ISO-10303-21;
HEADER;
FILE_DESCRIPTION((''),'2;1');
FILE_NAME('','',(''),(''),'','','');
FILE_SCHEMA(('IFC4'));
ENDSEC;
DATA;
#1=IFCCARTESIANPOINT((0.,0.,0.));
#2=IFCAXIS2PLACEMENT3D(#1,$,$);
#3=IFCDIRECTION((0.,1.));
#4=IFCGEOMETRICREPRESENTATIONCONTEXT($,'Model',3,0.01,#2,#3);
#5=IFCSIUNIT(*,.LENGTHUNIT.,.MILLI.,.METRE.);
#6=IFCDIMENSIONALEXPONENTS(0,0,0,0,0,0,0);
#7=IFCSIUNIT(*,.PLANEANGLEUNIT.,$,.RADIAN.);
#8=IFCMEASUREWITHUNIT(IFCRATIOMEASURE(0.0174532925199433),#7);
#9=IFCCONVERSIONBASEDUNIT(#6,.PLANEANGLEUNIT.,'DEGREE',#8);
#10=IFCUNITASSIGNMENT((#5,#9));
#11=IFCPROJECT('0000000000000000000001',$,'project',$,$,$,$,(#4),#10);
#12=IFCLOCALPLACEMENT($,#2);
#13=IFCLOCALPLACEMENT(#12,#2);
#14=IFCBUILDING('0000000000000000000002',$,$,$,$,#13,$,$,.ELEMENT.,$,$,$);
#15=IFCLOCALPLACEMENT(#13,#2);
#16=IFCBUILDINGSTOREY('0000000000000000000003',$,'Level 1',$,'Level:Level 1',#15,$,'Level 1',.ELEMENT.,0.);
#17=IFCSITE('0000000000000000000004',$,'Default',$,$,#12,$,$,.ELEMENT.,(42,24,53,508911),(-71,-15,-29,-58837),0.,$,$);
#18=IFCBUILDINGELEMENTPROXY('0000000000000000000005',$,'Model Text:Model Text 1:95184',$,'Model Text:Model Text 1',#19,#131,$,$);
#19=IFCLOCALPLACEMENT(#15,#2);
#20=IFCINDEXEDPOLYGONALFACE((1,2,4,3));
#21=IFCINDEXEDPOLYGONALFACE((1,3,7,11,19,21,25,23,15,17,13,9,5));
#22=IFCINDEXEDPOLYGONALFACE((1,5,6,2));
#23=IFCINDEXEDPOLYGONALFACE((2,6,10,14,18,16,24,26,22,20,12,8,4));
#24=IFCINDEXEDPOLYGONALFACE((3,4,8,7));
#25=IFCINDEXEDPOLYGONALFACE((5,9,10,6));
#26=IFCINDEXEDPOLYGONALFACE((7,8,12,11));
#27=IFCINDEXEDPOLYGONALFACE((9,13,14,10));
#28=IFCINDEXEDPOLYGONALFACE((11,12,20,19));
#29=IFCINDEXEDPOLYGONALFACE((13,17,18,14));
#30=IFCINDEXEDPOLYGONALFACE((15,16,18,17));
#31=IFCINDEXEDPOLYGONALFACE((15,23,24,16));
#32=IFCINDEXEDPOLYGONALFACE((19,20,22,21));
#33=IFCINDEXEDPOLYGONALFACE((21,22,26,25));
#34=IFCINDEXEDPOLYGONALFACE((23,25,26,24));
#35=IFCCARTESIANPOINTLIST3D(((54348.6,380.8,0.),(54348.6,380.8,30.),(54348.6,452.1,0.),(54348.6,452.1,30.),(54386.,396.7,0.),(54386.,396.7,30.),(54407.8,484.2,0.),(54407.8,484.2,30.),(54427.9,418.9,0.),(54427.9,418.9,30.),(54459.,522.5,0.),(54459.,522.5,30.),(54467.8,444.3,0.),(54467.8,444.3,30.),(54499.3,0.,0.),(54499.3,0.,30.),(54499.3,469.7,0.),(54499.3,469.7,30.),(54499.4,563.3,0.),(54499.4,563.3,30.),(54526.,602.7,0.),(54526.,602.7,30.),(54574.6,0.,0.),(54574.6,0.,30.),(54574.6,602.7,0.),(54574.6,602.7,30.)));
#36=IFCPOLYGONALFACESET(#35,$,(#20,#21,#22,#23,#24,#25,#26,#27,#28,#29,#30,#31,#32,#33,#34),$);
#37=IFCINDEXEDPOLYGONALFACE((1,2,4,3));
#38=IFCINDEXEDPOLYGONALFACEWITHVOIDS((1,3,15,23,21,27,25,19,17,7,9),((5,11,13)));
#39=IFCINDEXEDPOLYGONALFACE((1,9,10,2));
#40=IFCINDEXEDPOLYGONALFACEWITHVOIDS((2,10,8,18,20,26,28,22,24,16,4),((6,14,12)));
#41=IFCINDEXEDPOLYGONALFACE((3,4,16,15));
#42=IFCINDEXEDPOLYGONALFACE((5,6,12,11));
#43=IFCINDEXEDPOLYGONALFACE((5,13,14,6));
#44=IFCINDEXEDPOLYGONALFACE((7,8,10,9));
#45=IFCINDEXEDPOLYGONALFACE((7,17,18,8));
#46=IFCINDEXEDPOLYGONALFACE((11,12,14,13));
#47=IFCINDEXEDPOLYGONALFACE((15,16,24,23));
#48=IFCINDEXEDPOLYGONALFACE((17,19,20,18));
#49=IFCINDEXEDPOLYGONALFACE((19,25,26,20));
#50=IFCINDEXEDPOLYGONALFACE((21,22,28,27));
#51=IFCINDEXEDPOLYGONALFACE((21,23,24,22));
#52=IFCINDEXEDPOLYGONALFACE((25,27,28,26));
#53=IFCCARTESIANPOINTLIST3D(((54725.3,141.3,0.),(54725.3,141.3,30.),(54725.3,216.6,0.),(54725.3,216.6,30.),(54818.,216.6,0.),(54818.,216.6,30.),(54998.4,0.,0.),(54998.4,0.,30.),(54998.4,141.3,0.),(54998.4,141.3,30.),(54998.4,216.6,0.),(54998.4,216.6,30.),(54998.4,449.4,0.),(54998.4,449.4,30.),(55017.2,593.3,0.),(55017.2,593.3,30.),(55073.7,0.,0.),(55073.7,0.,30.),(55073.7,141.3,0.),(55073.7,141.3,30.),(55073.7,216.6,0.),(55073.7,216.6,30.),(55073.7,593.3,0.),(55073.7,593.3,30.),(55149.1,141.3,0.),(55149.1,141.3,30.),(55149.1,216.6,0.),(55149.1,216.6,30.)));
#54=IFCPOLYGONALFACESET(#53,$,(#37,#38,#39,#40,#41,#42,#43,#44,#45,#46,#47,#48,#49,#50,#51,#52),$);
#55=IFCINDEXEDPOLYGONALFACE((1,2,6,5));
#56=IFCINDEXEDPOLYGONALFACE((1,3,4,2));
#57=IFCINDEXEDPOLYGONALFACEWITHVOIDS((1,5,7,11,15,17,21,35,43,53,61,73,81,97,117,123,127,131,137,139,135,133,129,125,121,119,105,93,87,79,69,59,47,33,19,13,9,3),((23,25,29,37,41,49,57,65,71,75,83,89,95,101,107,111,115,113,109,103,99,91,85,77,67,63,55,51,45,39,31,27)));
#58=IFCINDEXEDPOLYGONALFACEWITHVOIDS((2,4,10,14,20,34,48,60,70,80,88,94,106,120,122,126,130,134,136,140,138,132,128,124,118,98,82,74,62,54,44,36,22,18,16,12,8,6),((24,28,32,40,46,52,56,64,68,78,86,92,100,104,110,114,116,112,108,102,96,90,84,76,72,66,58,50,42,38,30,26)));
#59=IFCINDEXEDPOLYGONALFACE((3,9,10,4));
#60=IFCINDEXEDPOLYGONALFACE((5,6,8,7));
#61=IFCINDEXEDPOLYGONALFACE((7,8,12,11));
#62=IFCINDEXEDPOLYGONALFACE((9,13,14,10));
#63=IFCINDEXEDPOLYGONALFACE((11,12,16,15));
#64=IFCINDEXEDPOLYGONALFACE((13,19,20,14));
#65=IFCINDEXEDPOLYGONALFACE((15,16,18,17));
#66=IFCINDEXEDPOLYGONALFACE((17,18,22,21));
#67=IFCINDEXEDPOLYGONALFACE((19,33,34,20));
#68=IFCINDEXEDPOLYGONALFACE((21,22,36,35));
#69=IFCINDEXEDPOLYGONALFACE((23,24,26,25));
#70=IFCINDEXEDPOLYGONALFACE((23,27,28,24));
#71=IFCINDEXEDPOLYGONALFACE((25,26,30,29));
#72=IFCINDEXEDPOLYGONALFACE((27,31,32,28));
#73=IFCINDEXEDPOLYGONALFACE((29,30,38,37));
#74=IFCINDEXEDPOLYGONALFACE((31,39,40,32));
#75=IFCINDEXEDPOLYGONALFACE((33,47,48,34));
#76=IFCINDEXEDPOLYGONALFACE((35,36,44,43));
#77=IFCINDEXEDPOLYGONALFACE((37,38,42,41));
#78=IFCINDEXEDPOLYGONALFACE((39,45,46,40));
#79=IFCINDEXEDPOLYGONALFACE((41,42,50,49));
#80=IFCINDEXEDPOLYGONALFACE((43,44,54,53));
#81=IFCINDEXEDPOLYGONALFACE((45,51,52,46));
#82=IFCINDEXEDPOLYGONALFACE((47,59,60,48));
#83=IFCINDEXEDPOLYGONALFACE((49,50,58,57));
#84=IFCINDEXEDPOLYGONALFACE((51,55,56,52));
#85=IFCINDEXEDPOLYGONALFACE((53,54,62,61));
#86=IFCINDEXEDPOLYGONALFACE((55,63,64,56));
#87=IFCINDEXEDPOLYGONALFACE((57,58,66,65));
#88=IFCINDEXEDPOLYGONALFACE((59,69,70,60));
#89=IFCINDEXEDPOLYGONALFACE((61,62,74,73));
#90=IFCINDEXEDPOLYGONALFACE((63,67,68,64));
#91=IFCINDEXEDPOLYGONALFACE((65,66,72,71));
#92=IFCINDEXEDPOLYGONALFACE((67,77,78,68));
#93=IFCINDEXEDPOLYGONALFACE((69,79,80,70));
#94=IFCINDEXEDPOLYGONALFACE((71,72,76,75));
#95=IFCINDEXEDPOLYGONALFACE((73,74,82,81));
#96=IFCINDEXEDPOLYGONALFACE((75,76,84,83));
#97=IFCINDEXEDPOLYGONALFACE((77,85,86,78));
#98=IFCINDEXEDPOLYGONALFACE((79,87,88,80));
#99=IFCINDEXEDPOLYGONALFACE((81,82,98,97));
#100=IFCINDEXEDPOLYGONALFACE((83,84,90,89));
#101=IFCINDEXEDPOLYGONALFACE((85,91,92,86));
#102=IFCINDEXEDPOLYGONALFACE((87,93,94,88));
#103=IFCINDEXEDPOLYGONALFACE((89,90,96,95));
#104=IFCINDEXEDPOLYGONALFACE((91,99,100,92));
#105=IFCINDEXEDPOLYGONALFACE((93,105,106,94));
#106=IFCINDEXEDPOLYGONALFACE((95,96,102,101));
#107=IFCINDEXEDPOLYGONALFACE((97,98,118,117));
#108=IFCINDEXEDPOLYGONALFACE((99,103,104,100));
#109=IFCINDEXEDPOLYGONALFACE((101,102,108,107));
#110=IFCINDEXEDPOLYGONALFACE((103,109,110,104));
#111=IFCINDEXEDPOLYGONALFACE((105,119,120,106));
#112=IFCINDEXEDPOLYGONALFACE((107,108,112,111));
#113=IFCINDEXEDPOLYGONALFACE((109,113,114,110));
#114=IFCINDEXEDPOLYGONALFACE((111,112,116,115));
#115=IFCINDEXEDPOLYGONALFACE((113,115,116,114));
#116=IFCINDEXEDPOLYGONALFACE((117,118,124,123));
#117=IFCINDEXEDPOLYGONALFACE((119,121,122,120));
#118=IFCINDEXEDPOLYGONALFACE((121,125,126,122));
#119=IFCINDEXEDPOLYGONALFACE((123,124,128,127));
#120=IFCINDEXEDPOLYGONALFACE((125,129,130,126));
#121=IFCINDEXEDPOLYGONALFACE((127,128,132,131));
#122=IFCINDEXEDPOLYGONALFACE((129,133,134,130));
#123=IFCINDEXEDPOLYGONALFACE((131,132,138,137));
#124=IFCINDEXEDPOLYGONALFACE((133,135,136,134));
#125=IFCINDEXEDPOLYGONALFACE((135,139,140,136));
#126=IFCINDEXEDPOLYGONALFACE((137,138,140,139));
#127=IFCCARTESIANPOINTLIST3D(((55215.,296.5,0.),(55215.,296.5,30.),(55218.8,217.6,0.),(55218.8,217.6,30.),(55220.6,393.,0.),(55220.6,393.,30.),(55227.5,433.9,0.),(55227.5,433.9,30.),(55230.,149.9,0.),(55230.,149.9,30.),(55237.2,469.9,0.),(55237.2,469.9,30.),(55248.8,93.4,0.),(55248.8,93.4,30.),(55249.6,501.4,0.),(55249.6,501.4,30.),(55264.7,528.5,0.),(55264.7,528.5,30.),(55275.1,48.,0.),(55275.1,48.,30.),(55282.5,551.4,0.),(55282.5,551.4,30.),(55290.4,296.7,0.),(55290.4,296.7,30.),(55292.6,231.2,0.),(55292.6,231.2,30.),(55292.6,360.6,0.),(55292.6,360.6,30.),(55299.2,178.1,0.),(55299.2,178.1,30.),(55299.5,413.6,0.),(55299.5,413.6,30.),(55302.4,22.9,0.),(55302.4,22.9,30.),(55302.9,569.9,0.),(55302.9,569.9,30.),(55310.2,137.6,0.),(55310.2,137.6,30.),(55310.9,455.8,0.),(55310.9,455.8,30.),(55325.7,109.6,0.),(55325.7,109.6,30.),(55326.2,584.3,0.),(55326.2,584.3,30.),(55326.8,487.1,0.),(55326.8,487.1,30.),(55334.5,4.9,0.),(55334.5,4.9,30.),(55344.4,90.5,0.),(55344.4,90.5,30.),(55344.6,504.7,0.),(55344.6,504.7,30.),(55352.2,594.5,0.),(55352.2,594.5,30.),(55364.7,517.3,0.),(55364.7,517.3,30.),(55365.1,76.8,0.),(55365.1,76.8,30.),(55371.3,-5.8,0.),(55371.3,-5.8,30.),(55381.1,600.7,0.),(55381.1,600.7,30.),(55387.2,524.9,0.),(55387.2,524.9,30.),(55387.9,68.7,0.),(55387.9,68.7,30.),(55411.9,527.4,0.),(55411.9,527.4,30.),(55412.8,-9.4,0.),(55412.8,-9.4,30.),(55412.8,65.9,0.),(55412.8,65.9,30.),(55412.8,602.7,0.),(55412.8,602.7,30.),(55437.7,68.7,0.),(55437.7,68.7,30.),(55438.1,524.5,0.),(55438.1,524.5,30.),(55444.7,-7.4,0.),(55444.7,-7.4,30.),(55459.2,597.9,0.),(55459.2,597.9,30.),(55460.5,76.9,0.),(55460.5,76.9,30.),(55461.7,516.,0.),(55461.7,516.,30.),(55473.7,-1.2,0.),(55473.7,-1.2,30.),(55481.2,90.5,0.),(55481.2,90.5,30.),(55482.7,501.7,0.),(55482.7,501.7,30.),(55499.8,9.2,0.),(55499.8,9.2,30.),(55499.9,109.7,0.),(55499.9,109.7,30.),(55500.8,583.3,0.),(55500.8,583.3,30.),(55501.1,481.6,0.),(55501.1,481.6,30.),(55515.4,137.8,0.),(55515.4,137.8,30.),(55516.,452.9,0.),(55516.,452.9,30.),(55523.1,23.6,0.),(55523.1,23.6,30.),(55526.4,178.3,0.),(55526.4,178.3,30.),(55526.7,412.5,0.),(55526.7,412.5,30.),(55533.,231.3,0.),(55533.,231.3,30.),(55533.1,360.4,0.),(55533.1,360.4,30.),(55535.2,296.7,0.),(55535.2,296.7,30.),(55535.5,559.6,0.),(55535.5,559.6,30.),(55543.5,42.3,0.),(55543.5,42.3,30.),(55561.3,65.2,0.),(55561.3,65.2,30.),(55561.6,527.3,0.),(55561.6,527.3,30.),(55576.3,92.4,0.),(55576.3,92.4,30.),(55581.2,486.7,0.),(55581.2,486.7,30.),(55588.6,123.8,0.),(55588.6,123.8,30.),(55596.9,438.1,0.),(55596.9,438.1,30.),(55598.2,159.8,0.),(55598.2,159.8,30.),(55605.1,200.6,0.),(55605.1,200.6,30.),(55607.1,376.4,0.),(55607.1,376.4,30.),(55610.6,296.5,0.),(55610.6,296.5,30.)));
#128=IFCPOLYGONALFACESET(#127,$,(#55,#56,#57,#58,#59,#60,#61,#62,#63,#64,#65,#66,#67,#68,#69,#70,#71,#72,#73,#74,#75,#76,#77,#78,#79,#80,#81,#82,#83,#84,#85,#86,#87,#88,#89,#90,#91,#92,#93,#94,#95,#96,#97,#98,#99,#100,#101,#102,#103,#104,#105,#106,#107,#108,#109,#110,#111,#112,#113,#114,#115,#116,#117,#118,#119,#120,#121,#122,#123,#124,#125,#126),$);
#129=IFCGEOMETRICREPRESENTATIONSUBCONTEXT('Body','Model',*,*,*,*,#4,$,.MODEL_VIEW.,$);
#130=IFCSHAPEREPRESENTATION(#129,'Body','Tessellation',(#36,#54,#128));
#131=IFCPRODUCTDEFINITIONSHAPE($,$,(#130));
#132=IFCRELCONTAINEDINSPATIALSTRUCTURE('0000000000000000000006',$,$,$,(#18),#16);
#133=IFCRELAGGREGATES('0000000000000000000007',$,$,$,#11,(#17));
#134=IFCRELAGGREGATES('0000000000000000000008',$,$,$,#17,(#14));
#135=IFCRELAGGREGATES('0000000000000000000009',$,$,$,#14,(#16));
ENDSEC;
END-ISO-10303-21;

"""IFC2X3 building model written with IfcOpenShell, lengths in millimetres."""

from ifc_helpers import new_model, entity, si_unit, converted_unit, direction, frame, origin, place, context, subcontext, project, spatial, polyline, outline, extrude, element, save


model = new_model("IFC2X3")

# Units and contexts
model_context = context("Model", 3, precision=0.01, world=origin(), true_north=direction((0.0, 1.0)))
body_context = subcontext(model_context, "Body", "Model", "MODEL_VIEW")
ifc_project = project(units=[si_unit("LENGTHUNIT", "METRE", prefix="MILLI"), converted_unit("PLANEANGLEUNIT", "DEGREE", entity("IfcRatioMeasure", 0.0174532925199433), si_unit("PLANEANGLEUNIT", "RADIAN"), dimensions=[0, 0, 0, 0, 0, 0, 0])], contexts=[model_context])

# Site, building, storey
site_placement = place(None, origin())
site = spatial("IfcSite", under=ifc_project, at=site_placement, Name="Default", CompositionType="ELEMENT", RefLatitude=(42, 24, 53, 508911), RefLongitude=(-71, -15, -29, -58837), RefElevation=0.0)
building_placement = place(site_placement, origin())
building = spatial("IfcBuilding", under=site, at=building_placement, CompositionType="ELEMENT")
storey_placement = place(building_placement, origin())
storey = spatial("IfcBuildingStorey", under=building, at=storey_placement, Name="Level 1", ObjectType="Level:Level 1", LongName="Level 1", CompositionType="ELEMENT", Elevation=0.0)

# Building element proxy
proxy_1_placement = place(storey_placement, origin())
element("IfcBuildingElementProxy", 1, at=proxy_1_placement, inside=storey, Name="Model Text:Model Text 1:95184", ObjectType="Model Text:Model Text 1", context=body_context, shape_type="SweptSolid", body=[
    extrude(outline(polyline([(-410.6, -111.6), (192.1, -111.6), (192.1, -63.1), (152.7, -36.4), (111.9, 4.0), (73.6, 55.2), (41.4, 114.4), (-29.8, 114.4), (-13.9, 77.0), (8.3, 35.1), (33.7, -4.8), (59.1, -36.3), (-410.6, -36.3), (-410.6, -111.6)])), frame((54463.0, 410.6, 0.0), z_axis=(0.0, 0.0, 1.0), x_axis=(0.0, 1.0, 0.0)), (0.0, 0.0, 1.0), 30.0),
    extrude(outline(polyline([(-6.8, -218.3), (68.5, -218.3), (68.5, -77.1), (143.8, -77.1), (143.8, -1.7), (68.5, -1.7), (68.5, 375.0), (12.0, 375.0), (-280.0, -1.7), (-280.0, -77.1), (-6.8, -77.1), (-6.8, -218.3)]), holes=[polyline([(-6.8, -1.7), (-187.3, -1.7), (-6.8, 231.1), (-6.8, -1.7)])]), frame((55005.3, 218.3, 0.0)), (0.0, 0.0, 1.0), 30.0),
    extrude(outline(polyline([(-10.6, -198.7), (68.3, -198.7), (136.5, -190.7), (193.9, -174.7), (240.5, -150.6), (266.9, -124.4), (286.3, -93.2), (298.8, -57.0), (304.3, -15.7), (303.8, 16.2), (299.0, 45.5), (289.9, 72.1), (276.6, 96.0), (258.9, 117.3), (236.9, 136.2), (210.4, 152.5), (179.6, 166.3), (144.1, 177.6), (103.7, 186.3), (8.2, 196.4), (-71.8, 196.7), (-134.0, 189.4), (-183.3, 176.1), (-224.7, 158.4), (-258.2, 133.9), (-283.5, 100.3), (-300.1, 59.5), (-307.1, 13.4), (-306.6, -18.4), (-301.8, -47.5), (-292.8, -74.0), (-279.6, -97.9), (-262.0, -119.2), (-240.0, -138.1), (-213.6, -154.5), (-182.8, -168.4), (-147.3, -179.8), (-106.7, -188.6), (-10.6, -198.7)]), holes=[polyline([(-7.2, -123.5), (-71.0, -118.2), (-123.6, -108.8), (-165.2, -95.4), (-195.7, -78.0), (-212.4, -59.4), (-224.1, -38.7), (-230.6, -15.9), (-231.9, 8.9), (-227.8, 35.0), (-218.1, 58.1), (-202.8, 78.4), (-182.0, 95.8), (-152.6, 109.4), (-111.7, 118.1), (-59.4, 122.0), (4.4, 121.1), (69.6, 115.8), (122.2, 106.7), (162.2, 93.7), (189.5, 77.0), (207.7, 57.4), (220.4, 36.0), (227.5, 12.8), (229.1, -12.1), (225.2, -36.8), (215.9, -59.2), (201.3, -79.3), (181.4, -97.1), (152.6, -111.2), (111.6, -120.3), (58.3, -124.4), (-7.2, -123.5)])]), frame((55414.0, 295.3, 0.0), z_axis=(0.0, 0.0, 1.0), x_axis=(0.047515, -0.998871, 0.0)), (0.0, 0.0, 1.0), 30.0),
])

save(model, "model.ifc")
